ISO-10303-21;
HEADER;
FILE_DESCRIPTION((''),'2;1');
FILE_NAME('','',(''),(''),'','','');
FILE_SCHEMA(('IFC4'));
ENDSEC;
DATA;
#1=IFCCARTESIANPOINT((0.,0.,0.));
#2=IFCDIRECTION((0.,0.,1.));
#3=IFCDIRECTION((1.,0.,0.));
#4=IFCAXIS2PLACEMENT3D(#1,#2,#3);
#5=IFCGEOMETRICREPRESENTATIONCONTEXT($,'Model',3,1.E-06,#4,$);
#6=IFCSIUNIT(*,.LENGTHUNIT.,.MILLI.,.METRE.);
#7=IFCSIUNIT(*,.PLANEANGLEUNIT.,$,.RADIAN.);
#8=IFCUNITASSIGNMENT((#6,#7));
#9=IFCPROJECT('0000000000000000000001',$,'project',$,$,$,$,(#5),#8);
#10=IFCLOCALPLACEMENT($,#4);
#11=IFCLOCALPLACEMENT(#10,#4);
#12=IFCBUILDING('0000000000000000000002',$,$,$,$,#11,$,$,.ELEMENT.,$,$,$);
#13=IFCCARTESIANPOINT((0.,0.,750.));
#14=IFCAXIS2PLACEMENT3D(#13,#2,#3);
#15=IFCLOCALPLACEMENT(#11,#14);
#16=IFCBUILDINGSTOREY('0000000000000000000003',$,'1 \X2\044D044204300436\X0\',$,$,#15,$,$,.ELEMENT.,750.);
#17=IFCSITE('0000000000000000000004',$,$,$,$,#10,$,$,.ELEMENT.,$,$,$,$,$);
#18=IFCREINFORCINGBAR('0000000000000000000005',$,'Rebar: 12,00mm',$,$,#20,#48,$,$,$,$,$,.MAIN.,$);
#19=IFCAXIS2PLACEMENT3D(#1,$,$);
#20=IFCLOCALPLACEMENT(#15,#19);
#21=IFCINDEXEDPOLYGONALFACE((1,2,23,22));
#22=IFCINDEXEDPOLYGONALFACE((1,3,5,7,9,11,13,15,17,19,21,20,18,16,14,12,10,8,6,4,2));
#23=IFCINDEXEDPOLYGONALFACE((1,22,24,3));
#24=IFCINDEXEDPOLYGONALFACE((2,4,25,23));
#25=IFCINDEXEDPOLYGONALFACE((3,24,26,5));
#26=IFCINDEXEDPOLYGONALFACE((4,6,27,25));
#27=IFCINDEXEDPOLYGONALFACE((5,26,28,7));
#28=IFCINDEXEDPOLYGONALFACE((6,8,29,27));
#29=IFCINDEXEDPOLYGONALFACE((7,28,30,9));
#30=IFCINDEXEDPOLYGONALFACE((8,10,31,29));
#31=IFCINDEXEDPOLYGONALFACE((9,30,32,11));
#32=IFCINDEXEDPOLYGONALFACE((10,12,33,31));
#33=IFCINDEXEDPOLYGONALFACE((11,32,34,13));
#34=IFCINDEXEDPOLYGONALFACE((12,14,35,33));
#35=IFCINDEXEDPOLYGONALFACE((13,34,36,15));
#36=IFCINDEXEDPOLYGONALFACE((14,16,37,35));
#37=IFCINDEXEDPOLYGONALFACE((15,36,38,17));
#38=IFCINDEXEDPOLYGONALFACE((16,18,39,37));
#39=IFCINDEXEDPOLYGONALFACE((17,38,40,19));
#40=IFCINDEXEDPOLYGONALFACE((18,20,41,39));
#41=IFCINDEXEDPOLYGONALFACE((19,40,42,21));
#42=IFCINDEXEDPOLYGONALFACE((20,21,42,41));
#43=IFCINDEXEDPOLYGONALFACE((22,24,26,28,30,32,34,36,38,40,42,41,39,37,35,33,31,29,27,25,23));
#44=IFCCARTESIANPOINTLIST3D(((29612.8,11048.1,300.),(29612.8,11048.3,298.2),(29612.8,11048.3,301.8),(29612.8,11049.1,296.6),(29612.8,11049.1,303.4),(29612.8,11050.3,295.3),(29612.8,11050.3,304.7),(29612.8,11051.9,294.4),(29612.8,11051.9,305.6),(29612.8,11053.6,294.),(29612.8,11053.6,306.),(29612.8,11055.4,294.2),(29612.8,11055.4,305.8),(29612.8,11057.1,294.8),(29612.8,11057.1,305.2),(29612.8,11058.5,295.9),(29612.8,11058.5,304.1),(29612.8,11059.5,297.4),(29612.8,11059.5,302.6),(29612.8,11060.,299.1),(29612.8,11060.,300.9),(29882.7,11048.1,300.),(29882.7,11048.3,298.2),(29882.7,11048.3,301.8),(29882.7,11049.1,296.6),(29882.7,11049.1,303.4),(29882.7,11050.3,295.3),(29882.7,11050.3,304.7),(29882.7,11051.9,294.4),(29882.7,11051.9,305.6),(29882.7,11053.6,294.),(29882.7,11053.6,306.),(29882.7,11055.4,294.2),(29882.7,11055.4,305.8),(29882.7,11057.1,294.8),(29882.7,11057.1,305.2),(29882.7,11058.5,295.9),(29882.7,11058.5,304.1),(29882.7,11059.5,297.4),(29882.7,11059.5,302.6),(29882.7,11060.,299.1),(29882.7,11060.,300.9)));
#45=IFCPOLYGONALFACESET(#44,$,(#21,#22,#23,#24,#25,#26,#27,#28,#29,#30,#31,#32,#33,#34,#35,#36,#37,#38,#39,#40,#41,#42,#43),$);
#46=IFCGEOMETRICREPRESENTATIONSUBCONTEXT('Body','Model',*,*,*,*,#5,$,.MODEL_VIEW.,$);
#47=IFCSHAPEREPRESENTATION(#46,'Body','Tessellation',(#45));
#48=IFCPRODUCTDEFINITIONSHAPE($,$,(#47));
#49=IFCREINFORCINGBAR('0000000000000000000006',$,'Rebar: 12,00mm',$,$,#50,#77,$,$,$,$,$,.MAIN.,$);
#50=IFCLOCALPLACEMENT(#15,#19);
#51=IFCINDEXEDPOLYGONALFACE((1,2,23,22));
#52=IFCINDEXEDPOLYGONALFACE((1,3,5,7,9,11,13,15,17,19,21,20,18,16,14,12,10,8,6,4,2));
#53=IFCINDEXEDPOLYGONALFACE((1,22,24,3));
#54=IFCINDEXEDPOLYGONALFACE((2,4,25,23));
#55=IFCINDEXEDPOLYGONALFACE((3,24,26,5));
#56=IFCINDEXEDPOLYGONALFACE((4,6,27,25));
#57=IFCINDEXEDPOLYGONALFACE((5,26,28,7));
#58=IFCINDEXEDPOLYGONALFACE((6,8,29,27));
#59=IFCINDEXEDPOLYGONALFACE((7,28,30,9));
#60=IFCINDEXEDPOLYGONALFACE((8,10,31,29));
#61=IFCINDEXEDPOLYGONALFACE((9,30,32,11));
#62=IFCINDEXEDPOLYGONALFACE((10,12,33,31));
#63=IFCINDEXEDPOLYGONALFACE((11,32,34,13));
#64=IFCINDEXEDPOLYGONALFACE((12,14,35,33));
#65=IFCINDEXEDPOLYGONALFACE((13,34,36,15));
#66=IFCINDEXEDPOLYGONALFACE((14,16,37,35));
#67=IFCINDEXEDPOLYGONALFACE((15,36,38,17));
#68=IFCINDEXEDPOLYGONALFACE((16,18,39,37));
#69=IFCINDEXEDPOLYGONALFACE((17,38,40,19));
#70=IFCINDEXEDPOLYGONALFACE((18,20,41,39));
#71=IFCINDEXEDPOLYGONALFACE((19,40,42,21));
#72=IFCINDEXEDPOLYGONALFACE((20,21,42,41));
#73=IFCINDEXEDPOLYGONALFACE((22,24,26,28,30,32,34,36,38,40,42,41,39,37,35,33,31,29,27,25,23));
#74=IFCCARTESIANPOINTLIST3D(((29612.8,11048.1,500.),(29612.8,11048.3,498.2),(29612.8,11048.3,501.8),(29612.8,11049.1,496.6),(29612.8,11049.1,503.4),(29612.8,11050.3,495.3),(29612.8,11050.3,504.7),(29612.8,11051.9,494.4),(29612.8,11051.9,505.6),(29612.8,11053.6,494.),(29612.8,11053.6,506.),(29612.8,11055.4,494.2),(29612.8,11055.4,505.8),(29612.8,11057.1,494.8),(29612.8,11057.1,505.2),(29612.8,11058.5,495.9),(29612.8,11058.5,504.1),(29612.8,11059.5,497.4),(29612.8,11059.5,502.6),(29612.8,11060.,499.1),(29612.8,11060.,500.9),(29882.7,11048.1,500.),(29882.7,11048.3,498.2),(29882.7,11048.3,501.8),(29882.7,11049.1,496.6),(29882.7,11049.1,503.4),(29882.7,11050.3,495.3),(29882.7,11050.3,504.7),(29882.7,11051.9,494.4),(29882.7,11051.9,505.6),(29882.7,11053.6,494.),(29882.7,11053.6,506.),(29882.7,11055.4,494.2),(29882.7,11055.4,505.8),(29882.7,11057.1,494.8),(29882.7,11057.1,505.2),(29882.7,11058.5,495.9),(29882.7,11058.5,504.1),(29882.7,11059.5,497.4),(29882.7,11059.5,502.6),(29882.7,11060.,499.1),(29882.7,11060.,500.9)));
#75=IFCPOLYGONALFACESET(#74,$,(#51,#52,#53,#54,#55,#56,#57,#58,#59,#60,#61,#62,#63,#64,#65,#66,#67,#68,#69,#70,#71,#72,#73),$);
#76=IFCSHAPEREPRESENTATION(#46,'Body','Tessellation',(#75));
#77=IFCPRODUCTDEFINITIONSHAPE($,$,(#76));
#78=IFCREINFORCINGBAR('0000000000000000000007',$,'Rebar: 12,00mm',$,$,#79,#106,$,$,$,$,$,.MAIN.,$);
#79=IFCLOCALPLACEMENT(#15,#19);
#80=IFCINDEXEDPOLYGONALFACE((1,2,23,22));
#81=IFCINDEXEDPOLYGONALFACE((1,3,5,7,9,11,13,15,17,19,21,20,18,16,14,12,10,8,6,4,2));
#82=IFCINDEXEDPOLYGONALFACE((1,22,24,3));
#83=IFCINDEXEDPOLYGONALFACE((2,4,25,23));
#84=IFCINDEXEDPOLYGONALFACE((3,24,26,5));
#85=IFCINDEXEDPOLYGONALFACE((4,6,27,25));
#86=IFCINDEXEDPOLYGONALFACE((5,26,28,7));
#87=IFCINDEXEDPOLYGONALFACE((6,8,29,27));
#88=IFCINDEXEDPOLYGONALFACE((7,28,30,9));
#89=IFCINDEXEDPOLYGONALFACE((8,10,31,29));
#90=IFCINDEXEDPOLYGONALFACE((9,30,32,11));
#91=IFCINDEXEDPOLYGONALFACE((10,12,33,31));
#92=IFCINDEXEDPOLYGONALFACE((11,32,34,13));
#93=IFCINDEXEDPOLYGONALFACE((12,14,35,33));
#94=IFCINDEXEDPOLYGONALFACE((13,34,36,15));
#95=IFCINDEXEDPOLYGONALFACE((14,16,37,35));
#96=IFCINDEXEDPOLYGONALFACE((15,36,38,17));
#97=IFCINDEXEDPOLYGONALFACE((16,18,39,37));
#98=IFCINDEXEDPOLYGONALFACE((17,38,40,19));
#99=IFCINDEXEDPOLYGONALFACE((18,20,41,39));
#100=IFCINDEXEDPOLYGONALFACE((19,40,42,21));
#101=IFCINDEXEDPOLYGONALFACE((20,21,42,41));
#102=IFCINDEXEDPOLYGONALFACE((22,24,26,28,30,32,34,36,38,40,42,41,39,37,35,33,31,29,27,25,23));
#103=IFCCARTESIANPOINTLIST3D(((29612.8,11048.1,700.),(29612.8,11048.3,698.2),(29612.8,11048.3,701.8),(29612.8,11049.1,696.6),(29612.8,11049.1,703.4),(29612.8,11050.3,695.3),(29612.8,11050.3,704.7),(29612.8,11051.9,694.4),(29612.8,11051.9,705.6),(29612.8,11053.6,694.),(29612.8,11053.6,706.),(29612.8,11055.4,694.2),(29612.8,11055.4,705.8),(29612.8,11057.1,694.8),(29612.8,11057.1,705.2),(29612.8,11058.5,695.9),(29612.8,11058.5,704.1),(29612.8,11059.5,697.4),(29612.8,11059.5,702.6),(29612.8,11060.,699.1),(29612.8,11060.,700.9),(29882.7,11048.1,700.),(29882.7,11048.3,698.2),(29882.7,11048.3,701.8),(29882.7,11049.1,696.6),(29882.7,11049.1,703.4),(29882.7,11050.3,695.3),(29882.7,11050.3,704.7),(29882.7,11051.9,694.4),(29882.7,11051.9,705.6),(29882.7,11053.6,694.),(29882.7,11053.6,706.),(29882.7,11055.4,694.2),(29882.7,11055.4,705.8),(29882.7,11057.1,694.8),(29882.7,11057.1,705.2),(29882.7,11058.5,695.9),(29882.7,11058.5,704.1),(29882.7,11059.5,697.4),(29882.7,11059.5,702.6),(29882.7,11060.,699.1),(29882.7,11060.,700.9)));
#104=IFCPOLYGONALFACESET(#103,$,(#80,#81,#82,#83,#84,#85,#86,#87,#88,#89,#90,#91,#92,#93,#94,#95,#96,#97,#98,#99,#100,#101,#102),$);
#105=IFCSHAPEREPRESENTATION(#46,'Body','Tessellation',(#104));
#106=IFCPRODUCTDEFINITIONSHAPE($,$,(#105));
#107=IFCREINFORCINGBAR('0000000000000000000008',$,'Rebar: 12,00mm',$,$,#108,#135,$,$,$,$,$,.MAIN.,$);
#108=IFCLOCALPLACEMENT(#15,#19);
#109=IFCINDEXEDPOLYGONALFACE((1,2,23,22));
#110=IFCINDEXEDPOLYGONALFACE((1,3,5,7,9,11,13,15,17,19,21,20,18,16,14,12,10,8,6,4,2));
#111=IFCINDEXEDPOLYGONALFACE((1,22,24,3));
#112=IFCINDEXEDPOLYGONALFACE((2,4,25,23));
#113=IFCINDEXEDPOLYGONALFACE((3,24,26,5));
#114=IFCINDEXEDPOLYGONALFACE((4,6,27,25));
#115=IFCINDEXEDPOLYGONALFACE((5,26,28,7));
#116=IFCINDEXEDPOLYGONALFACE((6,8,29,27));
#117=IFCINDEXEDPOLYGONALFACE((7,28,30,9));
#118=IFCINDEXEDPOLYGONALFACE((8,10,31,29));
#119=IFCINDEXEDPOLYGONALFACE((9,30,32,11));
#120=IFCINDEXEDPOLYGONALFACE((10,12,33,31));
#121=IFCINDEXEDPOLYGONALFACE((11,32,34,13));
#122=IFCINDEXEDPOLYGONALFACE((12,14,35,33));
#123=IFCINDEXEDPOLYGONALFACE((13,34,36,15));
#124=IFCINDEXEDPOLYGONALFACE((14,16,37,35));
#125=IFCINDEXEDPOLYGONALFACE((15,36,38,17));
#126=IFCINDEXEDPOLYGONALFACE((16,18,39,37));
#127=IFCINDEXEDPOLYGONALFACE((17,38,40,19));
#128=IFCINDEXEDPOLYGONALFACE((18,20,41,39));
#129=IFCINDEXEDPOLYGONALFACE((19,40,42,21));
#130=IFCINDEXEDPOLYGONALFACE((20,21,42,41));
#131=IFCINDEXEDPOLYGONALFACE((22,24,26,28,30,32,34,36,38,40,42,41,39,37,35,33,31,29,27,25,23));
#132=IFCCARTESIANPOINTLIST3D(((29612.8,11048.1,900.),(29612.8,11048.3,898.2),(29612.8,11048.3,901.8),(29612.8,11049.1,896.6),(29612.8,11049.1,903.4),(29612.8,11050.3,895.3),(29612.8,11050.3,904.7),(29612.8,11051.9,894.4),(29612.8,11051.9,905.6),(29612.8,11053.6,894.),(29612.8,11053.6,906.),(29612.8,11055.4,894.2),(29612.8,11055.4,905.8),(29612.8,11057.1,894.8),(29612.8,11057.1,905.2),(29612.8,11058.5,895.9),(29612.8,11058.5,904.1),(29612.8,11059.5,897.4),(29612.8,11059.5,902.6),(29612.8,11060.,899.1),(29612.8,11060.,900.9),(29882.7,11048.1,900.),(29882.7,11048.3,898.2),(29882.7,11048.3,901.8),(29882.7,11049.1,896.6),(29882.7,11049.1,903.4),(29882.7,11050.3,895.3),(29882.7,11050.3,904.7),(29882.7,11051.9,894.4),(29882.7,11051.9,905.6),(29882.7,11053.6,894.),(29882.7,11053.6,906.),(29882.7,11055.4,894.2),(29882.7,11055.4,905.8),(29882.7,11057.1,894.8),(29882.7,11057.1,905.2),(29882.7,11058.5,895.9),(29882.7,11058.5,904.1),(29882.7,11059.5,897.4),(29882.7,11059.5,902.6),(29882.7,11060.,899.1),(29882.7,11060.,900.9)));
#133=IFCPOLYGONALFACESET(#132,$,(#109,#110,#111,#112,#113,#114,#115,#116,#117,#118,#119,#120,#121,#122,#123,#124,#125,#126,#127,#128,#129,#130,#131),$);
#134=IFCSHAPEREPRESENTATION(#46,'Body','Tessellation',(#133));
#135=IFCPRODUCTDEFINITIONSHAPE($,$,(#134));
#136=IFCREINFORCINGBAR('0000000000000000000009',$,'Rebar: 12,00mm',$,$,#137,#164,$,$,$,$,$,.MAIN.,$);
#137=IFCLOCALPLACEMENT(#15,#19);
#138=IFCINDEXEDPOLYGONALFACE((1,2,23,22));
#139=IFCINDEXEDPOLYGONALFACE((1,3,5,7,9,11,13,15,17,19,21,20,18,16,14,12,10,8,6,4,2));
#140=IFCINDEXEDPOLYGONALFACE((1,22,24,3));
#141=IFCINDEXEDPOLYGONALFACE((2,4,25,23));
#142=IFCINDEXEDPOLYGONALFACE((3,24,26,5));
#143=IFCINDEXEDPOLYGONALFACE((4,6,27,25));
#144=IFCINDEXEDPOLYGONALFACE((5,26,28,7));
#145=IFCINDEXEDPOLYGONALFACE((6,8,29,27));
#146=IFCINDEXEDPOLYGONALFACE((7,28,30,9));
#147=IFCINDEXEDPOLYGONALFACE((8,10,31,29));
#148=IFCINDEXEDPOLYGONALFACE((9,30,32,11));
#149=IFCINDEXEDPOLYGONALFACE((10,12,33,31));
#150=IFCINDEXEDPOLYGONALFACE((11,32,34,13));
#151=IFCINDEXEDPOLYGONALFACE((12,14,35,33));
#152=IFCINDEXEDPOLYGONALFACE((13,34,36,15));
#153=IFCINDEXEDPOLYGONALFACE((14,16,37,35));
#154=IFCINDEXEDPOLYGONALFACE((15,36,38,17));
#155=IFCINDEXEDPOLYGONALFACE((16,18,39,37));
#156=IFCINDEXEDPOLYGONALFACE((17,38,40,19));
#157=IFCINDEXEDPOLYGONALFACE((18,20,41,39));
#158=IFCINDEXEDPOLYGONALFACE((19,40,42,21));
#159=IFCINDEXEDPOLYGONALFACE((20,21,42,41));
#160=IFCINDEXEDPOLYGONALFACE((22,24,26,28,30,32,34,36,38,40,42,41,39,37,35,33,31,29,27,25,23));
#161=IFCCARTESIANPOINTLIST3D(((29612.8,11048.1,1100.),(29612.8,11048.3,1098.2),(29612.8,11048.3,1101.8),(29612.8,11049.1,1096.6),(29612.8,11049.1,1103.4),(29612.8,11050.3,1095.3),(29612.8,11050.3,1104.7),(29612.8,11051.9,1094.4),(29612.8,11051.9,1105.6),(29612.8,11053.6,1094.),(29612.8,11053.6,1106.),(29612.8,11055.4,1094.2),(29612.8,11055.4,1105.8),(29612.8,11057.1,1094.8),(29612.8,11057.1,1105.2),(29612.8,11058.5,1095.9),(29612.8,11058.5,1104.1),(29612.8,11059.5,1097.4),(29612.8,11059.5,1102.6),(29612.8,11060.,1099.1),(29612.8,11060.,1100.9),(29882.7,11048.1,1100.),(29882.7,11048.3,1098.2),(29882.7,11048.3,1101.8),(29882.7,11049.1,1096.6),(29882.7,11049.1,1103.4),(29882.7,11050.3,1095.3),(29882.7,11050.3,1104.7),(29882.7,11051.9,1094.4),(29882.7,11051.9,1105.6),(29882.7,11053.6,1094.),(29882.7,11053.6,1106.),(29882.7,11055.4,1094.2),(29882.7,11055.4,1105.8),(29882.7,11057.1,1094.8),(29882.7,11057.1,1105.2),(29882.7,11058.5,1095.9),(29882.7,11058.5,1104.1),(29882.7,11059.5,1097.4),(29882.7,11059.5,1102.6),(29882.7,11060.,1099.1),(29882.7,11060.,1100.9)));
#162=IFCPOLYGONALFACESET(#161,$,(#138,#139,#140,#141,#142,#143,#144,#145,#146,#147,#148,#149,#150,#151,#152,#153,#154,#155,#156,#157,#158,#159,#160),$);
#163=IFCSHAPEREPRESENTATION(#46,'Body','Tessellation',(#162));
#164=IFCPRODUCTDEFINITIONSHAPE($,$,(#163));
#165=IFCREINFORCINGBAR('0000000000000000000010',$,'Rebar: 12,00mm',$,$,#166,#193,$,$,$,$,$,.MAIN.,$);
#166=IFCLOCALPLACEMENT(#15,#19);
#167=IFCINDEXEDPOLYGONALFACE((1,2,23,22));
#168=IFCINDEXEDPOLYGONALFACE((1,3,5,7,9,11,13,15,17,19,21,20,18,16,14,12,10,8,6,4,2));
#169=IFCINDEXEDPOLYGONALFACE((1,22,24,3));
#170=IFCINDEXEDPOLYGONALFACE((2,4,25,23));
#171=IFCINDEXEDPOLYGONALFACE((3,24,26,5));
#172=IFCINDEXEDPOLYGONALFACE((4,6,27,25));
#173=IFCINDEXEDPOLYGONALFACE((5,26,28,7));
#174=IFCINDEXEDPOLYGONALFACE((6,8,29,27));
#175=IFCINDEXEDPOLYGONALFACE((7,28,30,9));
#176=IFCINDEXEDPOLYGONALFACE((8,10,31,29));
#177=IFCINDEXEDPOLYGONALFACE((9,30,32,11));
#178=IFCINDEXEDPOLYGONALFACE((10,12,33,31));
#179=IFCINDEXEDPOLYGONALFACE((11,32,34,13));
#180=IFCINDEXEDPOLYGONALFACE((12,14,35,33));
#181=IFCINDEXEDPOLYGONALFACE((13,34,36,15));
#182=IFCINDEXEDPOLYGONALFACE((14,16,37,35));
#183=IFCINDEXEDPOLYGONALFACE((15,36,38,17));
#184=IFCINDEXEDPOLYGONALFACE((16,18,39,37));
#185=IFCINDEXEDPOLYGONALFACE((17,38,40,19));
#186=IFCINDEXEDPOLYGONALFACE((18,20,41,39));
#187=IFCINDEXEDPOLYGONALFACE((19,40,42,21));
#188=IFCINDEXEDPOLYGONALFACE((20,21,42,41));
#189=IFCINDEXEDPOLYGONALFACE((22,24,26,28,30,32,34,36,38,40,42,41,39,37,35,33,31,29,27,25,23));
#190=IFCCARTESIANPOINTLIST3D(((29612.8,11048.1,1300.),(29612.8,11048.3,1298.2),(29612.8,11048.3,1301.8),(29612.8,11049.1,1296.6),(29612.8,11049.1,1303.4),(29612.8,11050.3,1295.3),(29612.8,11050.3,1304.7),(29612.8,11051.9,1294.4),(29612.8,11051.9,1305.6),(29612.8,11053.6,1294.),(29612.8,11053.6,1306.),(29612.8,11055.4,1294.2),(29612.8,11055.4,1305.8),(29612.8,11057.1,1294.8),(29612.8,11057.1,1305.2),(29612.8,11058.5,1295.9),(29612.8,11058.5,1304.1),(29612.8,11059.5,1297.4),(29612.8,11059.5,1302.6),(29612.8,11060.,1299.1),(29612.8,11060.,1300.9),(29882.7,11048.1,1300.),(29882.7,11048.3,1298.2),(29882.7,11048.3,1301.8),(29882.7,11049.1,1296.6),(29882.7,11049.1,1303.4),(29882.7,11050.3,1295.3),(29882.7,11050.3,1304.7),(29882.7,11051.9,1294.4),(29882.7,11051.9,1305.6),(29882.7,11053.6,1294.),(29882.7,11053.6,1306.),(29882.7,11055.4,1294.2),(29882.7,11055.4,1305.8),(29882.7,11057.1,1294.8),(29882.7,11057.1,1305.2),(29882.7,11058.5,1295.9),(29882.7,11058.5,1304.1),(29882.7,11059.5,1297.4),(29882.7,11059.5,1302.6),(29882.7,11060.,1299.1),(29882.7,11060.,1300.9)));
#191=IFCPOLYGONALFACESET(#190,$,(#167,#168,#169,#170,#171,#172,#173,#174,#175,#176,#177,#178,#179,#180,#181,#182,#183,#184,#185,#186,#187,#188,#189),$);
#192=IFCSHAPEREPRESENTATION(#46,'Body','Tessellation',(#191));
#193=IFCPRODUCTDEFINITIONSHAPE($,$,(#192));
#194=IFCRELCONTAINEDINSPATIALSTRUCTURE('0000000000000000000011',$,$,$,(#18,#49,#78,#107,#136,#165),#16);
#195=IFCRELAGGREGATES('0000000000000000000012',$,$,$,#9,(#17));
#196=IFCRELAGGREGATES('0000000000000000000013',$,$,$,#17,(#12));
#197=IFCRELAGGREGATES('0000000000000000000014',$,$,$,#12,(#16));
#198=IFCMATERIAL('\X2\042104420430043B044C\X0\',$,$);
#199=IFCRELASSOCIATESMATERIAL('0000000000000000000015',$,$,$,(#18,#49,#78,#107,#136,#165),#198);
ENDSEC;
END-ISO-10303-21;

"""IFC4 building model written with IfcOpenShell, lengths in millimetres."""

from ifc_helpers import new_model, entity, si_unit, frame, origin_with_axes, place, context, subcontext, project, spatial, source, transform, mapped, material, element, save


model = new_model("IFC4")

# Units and contexts
model_context = context("Model", 3, precision=1e-06, world=origin_with_axes())
body_context = subcontext(model_context, "Body", "Model", "MODEL_VIEW")
ifc_project = project(units=[si_unit("LENGTHUNIT", "METRE", prefix="MILLI"), si_unit("PLANEANGLEUNIT", "RADIAN")], contexts=[model_context])

# Site, building, storey
site_placement = place(None, origin_with_axes())
site = spatial("IfcSite", under=ifc_project, at=site_placement, CompositionType="ELEMENT")
building_placement = place(site_placement, origin_with_axes())
building = spatial("IfcBuilding", under=site, at=building_placement, CompositionType="ELEMENT")
storey_placement = place(building_placement, frame((0.0, 0.0, 750.0), z_axis=(0.0, 0.0, 1.0), x_axis=(1.0, 0.0, 0.0)))
storey = spatial("IfcBuildingStorey", under=building, at=storey_placement, Name="1 этаж", CompositionType="ELEMENT", Elevation=750.0)

# Reinforcing bars
ifc_material = material(Name="Сталь")
shared_shape_1 = source(origin_with_axes(), body_context, "Body", "AdvancedSweptSolid", [
    entity("IfcSweptDiskSolid", entity("IfcIndexedPolyCurve", entity("IfcCartesianPointList3D", [[0.0, 0.0, 0.0], [270.0, 0.0, 0.0]]), [entity("IfcLineIndex", [1, 2])]), 6.0),
])
reinforcing_bar_1_placement = place(storey_placement, origin_with_axes())
element("IfcReinforcingBar", 1, at=reinforcing_bar_1_placement, inside=storey, material=ifc_material, Name="Rebar: 12,00mm", PredefinedType="MAIN", context=body_context, shape_type="MappedRepresentation", body=[
    mapped(shared_shape_1, transform((29882.7, 11054.1, 300.0), x_axis=(-1.0, 0.0, 0.0), y_axis=(0.0, -1.0, 0.0), z_axis=(0.0, 0.0, 1.0), scale=1.0)),
])
reinforcing_bar_2_placement = place(storey_placement, origin_with_axes())
element("IfcReinforcingBar", 2, at=reinforcing_bar_2_placement, inside=storey, material=ifc_material, Name="Rebar: 12,00mm", PredefinedType="MAIN", context=body_context, shape_type="MappedRepresentation", body=[
    mapped(shared_shape_1, transform((29882.7, 11054.1, 500.0), x_axis=(-1.0, 0.0, 0.0), y_axis=(0.0, -1.0, 0.0), z_axis=(0.0, 0.0, 1.0), scale=1.0)),
])
reinforcing_bar_3_placement = place(storey_placement, origin_with_axes())
element("IfcReinforcingBar", 3, at=reinforcing_bar_3_placement, inside=storey, material=ifc_material, Name="Rebar: 12,00mm", PredefinedType="MAIN", context=body_context, shape_type="MappedRepresentation", body=[
    mapped(shared_shape_1, transform((29882.7, 11054.1, 700.0), x_axis=(-1.0, 0.0, 0.0), y_axis=(0.0, -1.0, 0.0), z_axis=(0.0, 0.0, 1.0), scale=1.0)),
])
reinforcing_bar_4_placement = place(storey_placement, origin_with_axes())
element("IfcReinforcingBar", 4, at=reinforcing_bar_4_placement, inside=storey, material=ifc_material, Name="Rebar: 12,00mm", PredefinedType="MAIN", context=body_context, shape_type="MappedRepresentation", body=[
    mapped(shared_shape_1, transform((29882.7, 11054.1, 900.0), x_axis=(-1.0, 0.0, 0.0), y_axis=(0.0, -1.0, 0.0), z_axis=(0.0, 0.0, 1.0), scale=1.0)),
])
reinforcing_bar_5_placement = place(storey_placement, origin_with_axes())
element("IfcReinforcingBar", 5, at=reinforcing_bar_5_placement, inside=storey, material=ifc_material, Name="Rebar: 12,00mm", PredefinedType="MAIN", context=body_context, shape_type="MappedRepresentation", body=[
    mapped(shared_shape_1, transform((29882.7, 11054.1, 1100.0), x_axis=(-1.0, 0.0, 0.0), y_axis=(0.0, -1.0, 0.0), z_axis=(0.0, 0.0, 1.0), scale=1.0)),
])
reinforcing_bar_6_placement = place(storey_placement, origin_with_axes())
element("IfcReinforcingBar", 6, at=reinforcing_bar_6_placement, inside=storey, material=ifc_material, Name="Rebar: 12,00mm", PredefinedType="MAIN", context=body_context, shape_type="MappedRepresentation", body=[
    mapped(shared_shape_1, transform((29882.7, 11054.1, 1300.0), x_axis=(-1.0, 0.0, 0.0), y_axis=(0.0, -1.0, 0.0), z_axis=(0.0, 0.0, 1.0), scale=1.0)),
])

save(model, "model.ifc")
